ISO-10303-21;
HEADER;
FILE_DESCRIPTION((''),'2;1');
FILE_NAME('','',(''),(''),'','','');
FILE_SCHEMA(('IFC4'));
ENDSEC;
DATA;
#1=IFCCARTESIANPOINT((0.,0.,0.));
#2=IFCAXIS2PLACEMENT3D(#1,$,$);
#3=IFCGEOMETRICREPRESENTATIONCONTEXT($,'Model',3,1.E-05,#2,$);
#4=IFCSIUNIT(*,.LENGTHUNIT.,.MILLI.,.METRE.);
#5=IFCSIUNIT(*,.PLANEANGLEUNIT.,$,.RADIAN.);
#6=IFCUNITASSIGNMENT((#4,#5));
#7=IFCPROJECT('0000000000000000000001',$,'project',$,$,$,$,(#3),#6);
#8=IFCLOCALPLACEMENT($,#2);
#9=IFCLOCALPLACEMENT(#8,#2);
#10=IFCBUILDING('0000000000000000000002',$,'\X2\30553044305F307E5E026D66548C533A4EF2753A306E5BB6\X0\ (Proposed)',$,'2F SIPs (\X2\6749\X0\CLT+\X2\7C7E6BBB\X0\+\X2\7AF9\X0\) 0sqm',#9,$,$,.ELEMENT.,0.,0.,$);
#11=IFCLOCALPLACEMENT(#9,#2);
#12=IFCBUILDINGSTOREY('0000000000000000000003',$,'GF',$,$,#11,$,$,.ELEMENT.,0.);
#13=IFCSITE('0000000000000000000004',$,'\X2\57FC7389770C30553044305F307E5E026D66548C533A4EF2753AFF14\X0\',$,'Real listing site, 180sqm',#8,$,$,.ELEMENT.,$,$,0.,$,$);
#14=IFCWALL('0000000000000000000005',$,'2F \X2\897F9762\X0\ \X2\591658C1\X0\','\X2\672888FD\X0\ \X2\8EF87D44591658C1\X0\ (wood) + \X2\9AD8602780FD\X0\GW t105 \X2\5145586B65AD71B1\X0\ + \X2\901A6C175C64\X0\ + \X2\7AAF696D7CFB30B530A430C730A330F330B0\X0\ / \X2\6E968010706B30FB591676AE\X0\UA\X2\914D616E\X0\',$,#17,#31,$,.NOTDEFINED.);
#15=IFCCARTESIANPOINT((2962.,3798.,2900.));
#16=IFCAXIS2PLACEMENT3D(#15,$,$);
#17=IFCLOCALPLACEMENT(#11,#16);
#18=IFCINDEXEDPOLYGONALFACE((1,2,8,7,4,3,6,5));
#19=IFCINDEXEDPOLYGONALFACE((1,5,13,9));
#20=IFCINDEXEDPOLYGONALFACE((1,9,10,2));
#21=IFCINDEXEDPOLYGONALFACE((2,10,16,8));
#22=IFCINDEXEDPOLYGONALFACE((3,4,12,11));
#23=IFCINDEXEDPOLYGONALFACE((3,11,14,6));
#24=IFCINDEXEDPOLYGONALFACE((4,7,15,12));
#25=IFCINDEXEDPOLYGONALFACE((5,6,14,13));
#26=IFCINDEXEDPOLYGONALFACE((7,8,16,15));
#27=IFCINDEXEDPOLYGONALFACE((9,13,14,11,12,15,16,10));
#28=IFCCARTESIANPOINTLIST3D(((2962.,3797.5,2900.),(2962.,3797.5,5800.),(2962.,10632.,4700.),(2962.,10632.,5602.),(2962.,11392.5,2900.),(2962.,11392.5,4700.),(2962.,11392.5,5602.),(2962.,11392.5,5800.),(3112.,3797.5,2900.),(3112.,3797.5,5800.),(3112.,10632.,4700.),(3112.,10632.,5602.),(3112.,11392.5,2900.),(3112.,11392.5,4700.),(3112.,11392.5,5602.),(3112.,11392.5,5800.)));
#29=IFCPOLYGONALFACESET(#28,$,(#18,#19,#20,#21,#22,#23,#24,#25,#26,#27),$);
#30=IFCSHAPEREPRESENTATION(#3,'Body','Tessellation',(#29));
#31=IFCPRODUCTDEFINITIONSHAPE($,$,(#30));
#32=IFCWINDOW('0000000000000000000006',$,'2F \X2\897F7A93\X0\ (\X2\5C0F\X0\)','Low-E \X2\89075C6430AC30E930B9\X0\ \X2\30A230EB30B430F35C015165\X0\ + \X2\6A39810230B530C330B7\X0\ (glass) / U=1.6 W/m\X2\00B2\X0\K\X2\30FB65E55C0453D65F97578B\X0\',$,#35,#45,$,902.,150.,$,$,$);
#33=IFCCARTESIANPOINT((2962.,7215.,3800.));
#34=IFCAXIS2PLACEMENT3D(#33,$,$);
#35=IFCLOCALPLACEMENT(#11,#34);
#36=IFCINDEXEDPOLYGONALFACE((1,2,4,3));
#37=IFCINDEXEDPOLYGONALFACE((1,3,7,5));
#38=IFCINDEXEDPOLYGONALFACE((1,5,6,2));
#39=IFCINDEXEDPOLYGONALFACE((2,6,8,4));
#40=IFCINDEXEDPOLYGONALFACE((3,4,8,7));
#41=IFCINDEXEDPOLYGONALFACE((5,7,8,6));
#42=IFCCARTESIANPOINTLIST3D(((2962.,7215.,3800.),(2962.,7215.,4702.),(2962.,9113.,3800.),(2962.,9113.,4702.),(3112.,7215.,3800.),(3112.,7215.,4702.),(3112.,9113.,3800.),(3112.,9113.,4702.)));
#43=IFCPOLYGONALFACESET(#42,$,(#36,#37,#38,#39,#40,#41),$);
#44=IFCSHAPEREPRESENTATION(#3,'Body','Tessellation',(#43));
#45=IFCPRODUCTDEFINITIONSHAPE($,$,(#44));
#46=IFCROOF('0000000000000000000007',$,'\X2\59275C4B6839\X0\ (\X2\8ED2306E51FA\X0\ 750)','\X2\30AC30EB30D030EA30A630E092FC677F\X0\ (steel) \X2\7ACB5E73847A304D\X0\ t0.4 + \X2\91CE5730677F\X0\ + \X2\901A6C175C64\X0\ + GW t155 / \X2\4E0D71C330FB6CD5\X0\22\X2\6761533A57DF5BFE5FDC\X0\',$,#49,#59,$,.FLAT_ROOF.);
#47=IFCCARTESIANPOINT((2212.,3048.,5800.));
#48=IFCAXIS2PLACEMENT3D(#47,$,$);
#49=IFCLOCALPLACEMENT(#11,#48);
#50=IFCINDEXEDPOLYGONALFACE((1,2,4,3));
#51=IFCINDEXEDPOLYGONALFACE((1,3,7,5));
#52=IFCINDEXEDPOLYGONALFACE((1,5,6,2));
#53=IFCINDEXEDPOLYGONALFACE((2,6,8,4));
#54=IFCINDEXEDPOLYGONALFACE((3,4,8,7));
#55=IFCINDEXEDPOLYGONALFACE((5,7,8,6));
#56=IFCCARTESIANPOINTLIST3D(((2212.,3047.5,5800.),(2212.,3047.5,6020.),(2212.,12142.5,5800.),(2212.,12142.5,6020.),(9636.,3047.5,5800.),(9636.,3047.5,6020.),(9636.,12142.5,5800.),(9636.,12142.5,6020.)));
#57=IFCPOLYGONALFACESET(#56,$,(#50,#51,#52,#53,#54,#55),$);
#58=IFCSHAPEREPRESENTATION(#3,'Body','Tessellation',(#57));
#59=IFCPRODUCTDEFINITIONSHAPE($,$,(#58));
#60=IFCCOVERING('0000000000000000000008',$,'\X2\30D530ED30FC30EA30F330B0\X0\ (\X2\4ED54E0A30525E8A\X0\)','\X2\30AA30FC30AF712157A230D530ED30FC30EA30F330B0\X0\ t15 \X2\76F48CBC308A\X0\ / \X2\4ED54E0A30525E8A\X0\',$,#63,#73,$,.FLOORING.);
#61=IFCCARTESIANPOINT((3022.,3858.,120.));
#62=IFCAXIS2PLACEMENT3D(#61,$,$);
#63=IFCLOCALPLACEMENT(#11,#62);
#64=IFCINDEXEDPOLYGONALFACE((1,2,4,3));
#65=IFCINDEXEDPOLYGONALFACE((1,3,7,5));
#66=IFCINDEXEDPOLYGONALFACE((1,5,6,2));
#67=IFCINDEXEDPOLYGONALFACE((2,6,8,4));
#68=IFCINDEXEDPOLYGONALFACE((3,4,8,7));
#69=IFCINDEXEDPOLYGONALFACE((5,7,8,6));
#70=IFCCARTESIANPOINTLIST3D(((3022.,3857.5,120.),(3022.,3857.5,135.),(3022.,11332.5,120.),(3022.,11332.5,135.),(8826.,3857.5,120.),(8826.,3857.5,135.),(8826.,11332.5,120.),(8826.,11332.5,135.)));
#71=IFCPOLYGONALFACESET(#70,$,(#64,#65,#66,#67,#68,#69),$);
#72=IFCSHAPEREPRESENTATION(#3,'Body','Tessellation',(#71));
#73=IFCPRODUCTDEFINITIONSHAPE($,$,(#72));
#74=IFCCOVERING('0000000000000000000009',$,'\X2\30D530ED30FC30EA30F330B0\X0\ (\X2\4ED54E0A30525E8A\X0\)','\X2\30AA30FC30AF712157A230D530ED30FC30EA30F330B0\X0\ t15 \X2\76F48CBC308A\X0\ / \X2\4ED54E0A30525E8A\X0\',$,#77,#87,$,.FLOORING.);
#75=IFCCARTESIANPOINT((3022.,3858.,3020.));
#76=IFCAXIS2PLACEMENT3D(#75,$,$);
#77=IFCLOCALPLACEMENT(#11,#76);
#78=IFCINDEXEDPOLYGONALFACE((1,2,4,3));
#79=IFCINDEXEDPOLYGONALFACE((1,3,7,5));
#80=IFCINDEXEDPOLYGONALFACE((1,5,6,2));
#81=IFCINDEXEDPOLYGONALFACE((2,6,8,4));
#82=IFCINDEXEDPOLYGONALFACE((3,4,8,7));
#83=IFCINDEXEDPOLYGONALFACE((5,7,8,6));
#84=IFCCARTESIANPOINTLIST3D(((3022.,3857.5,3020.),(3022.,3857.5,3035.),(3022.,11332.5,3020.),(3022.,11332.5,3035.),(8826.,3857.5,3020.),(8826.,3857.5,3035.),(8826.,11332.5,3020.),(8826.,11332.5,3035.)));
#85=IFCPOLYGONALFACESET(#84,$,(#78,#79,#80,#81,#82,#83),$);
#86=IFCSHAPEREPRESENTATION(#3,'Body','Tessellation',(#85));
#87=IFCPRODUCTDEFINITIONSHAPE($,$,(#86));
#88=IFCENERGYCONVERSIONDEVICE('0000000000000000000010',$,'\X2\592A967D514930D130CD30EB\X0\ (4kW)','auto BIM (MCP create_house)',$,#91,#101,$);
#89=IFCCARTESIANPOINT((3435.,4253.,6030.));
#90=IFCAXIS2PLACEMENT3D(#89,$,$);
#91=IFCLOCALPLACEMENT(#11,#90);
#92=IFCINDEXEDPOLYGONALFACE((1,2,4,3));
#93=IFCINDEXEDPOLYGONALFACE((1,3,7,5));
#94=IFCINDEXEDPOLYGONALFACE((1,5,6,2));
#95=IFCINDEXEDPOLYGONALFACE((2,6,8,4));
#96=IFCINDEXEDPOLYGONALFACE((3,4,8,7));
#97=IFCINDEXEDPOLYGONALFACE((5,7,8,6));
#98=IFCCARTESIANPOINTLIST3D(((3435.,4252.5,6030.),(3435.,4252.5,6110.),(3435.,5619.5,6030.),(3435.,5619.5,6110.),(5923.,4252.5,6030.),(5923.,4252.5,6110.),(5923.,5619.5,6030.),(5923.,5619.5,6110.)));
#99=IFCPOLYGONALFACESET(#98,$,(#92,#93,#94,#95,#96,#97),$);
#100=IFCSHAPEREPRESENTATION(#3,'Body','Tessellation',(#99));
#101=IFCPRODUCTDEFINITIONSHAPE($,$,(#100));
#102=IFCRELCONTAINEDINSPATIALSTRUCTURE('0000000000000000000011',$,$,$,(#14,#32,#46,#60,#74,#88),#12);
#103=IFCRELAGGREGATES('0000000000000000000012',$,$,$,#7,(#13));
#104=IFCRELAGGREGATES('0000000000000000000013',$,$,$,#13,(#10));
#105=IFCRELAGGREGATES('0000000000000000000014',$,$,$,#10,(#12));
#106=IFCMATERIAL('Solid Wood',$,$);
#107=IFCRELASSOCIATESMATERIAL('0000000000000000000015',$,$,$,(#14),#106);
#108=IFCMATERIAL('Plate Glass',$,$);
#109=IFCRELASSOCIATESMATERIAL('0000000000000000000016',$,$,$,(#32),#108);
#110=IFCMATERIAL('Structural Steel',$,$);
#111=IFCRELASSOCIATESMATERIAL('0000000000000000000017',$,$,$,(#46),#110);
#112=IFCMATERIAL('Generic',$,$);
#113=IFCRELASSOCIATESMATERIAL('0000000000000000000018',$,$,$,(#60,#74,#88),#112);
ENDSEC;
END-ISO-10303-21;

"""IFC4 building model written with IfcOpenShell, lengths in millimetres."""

from ifc_helpers import new_model, si_unit, frame, frame_2d, origin, place, context, project, spatial, rectangle, extrude, material, element, fill, save


model = new_model("IFC4")

# Units and contexts
model_context = context("Model", 3, precision=1e-05, world=origin())
ifc_project = project(units=[si_unit("LENGTHUNIT", "METRE", prefix="MILLI"), si_unit("PLANEANGLEUNIT", "RADIAN")], contexts=[model_context])

# Site, building, storey
site_placement = place(None, origin())
site = spatial("IfcSite", under=ifc_project, at=site_placement, Name="埼玉県さいたま市浦和区仲町４", ObjectType="Real listing site, 180sqm", CompositionType="ELEMENT", RefElevation=0.0)
building_placement = place(site_placement, origin())
building = spatial("IfcBuilding", under=site, at=building_placement, Name="さいたま市浦和区仲町の家 (Proposed)", ObjectType="2F SIPs (杉CLT+籾殻+竹) 0sqm", CompositionType="ELEMENT", ElevationOfRefHeight=0.0, ElevationOfTerrain=0.0)
storey_placement = place(building_placement, origin())
storey = spatial("IfcBuildingStorey", under=building, at=storey_placement, Name="GF", CompositionType="ELEMENT", Elevation=0.0)

# Shared definitions
ifc_material_1 = material(Name="Solid Wood")

# Shared definitions
ifc_material_2 = material(Name="Plate Glass")

# Wall, opening, window
wall_1_placement = place(storey_placement, frame((2962.0, 3798.0, 2900.0)))
wall_1 = element("IfcWall", 1, at=wall_1_placement, inside=storey, material=ifc_material_1, Name="2F 西面 外壁", Description="木製 軸組外壁 (wood) + 高性能GW t105 充填断熱 + 通気層 + 窯業系サイディング / 準耐火・外皮UA配慮", PredefinedType="NOTDEFINED", context=model_context, shape_type="SweptSolid", body=[
    extrude(rectangle(XDim=150.0, YDim=7595.0, at=frame_2d((75.0, 3797.0))), frame((2962.0, 3798.0, 2900.0)), (0.0, 0.0, 1.0), 2900.0),
])
opening_1_placement = place(storey_placement, frame((2962.0, 7215.0, 3800.0)))
opening_1 = element("IfcOpeningElement", 2, at=opening_1_placement, cuts=wall_1, PredefinedType="NOTDEFINED", context=model_context, shape_type="SweptSolid", body=[
    extrude(rectangle(XDim=150.0, YDim=1898.0, at=frame_2d((75.0, 949.0))), frame((2962.0, 7215.0, 3800.0)), (0.0, 0.0, 1.0), 902.0),
])
window_1_placement = place(storey_placement, frame((2962.0, 7215.0, 3800.0)))
window_1 = element("IfcWindow", 3, at=window_1_placement, inside=storey, material=ifc_material_2, Name="2F 西窓 (小)", Description="Low-E 複層ガラス アルゴン封入 + 樹脂サッシ (glass) / U=1.6 W/m²K・日射取得型", OverallHeight=902.0, OverallWidth=150.0, context=model_context, shape_type="SweptSolid", body=[
    extrude(rectangle(XDim=150.0, YDim=1898.0, at=frame_2d((75.0, 949.0))), frame((2962.0, 7215.0, 3800.0)), (0.0, 0.0, 1.0), 902.0),
])
fill(opening_1, window_1)

# Roof
ifc_material_3 = material(Name="Structural Steel")
roof_placement = place(storey_placement, frame((2212.0, 3048.0, 5800.0)))
element("IfcRoof", 4, at=roof_placement, inside=storey, material=ifc_material_3, Name="大屋根 (軒の出 750)", Description="ガルバリウム鋼板 (steel) 立平葺き t0.4 + 野地板 + 通気層 + GW t155 / 不燃・法22条区域対応", PredefinedType="FLAT_ROOF", context=model_context, shape_type="SweptSolid", body=[
    extrude(rectangle(XDim=7424.0, YDim=9095.0, at=frame_2d((3712.0, 4547.0))), frame((2212.0, 3048.0, 5800.0)), (0.0, 0.0, 1.0), 220.0),
])

# Coverings
ifc_material_4 = material(Name="Generic")
covering_1_placement = place(storey_placement, frame((3022.0, 3858.0, 120.0)))
element("IfcCovering", 5, at=covering_1_placement, inside=storey, material=ifc_material_4, Name="フローリング (仕上げ床)", Description="オーク無垢フローリング t15 直貼り / 仕上げ床", PredefinedType="FLOORING", context=model_context, shape_type="SweptSolid", body=[
    extrude(rectangle(XDim=5804.0, YDim=7475.0, at=frame_2d((2902.0, 3737.0))), frame((3022.0, 3858.0, 120.0)), (0.0, 0.0, 1.0), 15.0),
])
covering_2_placement = place(storey_placement, frame((3022.0, 3858.0, 3020.0)))
element("IfcCovering", 6, at=covering_2_placement, inside=storey, material=ifc_material_4, Name="フローリング (仕上げ床)", Description="オーク無垢フローリング t15 直貼り / 仕上げ床", PredefinedType="FLOORING", context=model_context, shape_type="SweptSolid", body=[
    extrude(rectangle(XDim=5804.0, YDim=7475.0, at=frame_2d((2902.0, 3737.0))), frame((3022.0, 3858.0, 3020.0)), (0.0, 0.0, 1.0), 15.0),
])

# Energy conversion device
energy_conversion_device_placement = place(storey_placement, frame((3435.0, 4253.0, 6030.0)))
element("IfcEnergyConversionDevice", 7, at=energy_conversion_device_placement, inside=storey, material=ifc_material_4, Name="太陽光パネル (4kW)", Description="auto BIM (MCP create_house)", context=model_context, shape_type="SweptSolid", body=[
    extrude(rectangle(XDim=2488.0, YDim=1367.0, at=frame_2d((1244.0, 683.0))), frame((3435.0, 4253.0, 6030.0)), (0.0, 0.0, 1.0), 80.0),
])

save(model, "model.ifc")
